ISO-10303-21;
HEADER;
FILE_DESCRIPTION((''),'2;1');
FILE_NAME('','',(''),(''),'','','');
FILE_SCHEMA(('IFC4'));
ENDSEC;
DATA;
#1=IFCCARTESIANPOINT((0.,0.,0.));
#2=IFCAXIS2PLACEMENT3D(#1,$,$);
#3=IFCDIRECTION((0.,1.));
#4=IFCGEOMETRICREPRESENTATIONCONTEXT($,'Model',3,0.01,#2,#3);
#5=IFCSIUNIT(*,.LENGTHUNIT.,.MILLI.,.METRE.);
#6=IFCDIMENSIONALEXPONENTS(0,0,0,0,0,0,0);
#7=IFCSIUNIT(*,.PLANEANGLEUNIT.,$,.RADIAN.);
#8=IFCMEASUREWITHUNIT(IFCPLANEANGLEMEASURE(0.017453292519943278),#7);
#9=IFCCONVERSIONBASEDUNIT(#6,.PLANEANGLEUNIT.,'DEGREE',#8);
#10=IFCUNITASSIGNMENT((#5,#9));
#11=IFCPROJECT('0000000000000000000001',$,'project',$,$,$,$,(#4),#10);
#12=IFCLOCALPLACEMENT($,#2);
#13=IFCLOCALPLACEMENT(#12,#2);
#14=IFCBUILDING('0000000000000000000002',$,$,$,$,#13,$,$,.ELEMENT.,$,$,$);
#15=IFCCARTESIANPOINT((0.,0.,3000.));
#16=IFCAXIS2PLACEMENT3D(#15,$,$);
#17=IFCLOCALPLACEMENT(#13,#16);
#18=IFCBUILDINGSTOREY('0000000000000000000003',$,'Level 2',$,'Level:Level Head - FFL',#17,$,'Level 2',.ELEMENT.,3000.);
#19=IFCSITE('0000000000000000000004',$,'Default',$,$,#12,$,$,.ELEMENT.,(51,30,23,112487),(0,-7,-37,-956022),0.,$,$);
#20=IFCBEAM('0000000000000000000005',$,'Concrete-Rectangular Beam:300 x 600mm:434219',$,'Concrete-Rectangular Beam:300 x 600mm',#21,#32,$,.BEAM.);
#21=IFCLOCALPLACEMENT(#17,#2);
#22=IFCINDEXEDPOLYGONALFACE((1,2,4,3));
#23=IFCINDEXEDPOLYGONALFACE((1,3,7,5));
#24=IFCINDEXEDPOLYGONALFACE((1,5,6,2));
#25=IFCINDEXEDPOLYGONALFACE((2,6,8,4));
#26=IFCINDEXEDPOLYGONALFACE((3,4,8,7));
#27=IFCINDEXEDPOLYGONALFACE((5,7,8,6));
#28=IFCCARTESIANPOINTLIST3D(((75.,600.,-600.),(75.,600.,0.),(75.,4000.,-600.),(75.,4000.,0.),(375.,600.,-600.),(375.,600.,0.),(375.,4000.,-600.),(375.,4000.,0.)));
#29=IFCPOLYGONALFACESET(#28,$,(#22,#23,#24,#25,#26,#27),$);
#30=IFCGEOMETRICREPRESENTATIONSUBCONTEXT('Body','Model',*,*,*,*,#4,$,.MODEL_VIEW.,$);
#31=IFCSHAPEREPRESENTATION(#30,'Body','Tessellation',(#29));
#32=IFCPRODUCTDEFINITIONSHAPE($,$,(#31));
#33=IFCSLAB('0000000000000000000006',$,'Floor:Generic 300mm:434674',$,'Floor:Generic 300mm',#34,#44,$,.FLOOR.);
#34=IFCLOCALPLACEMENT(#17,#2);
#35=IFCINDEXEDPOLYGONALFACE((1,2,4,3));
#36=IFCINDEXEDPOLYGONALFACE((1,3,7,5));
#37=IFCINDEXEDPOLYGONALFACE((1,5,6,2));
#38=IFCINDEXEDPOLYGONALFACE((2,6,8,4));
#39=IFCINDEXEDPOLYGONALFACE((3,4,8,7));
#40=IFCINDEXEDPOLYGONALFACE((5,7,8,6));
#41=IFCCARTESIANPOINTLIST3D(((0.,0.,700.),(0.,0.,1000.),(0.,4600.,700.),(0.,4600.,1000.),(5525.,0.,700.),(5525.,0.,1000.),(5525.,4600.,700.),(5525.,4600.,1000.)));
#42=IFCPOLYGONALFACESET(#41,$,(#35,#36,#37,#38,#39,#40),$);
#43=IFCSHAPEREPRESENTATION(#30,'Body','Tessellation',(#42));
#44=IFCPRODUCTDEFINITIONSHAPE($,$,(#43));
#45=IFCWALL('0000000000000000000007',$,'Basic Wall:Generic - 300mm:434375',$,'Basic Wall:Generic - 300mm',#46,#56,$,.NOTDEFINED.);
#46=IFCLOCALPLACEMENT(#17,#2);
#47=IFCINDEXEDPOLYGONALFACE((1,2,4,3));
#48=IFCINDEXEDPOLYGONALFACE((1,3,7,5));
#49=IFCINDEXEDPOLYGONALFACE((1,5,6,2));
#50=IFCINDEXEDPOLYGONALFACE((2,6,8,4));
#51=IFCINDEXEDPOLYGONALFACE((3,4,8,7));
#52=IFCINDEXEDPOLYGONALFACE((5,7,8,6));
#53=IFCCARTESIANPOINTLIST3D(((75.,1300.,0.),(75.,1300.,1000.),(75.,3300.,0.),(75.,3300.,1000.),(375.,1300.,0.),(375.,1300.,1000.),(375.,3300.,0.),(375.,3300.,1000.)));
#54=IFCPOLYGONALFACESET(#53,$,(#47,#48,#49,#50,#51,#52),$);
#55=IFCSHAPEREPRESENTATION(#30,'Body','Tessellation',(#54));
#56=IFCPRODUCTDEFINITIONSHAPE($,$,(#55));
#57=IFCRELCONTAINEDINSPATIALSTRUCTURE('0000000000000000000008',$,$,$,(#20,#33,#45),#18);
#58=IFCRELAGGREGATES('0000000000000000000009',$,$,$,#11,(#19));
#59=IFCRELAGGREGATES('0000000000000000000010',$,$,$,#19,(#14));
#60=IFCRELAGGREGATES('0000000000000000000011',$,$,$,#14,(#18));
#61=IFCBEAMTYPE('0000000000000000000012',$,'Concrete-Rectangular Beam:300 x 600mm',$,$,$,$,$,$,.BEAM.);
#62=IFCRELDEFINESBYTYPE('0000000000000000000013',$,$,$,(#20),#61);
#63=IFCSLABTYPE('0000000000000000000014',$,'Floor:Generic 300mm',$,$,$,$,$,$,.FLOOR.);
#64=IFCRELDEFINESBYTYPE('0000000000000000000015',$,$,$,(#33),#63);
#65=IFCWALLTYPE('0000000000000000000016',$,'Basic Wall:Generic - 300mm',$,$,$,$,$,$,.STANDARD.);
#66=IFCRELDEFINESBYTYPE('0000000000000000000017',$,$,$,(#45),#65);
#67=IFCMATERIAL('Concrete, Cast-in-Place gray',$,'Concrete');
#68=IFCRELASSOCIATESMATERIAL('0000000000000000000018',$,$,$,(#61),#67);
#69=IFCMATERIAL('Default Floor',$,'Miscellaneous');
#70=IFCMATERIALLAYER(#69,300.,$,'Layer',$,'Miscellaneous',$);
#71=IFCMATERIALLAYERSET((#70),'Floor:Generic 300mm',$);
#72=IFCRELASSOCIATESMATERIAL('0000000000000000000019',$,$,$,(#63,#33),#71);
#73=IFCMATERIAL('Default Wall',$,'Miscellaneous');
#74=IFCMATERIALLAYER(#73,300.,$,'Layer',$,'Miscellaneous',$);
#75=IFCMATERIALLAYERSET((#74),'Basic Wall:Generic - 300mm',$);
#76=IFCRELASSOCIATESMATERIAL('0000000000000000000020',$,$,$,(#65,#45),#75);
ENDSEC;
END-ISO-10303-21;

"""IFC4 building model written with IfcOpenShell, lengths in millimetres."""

from ifc_helpers import new_model, entity, si_unit, converted_unit, direction, frame, frame_2d, origin, origin_2d_with_axis, place, context, subcontext, project, spatial, rectangle, extrude, source, transform, mapped, material, layer, layer_set, layer_usage, material_profile, profile_set, type_object, type_shapes, element, save


model = new_model("IFC4")

# Units and contexts
model_context = context("Model", 3, precision=0.01, world=origin(), true_north=direction((0.0, 1.0)))
body_context = subcontext(model_context, "Body", "Model", "MODEL_VIEW")
ifc_project = project(units=[si_unit("LENGTHUNIT", "METRE", prefix="MILLI"), converted_unit("PLANEANGLEUNIT", "DEGREE", entity("IfcPlaneAngleMeasure", 0.017453292519943278), si_unit("PLANEANGLEUNIT", "RADIAN"), dimensions=[0, 0, 0, 0, 0, 0, 0])], contexts=[model_context])

# Site, building, storey
site_placement = place(None, origin())
site = spatial("IfcSite", under=ifc_project, at=site_placement, Name="Default", CompositionType="ELEMENT", RefLatitude=(51, 30, 23, 112487), RefLongitude=(0, -7, -37, -956022), RefElevation=0.0)
building_placement = place(site_placement, origin())
building = spatial("IfcBuilding", under=site, at=building_placement, CompositionType="ELEMENT")
storey_placement = place(building_placement, frame((0.0, 0.0, 3000.0)))
storey = spatial("IfcBuildingStorey", under=building, at=storey_placement, Name="Level 2", ObjectType="Level:Level Head - FFL", LongName="Level 2", CompositionType="ELEMENT", Elevation=3000.0)

# Beam
ifc_material_1 = material(Name="Concrete, Cast-in-Place gray", Category="Concrete")
ifc_material_profile = material_profile(ifc_material_1, rectangle(XDim=600.0, YDim=300.0, at=frame_2d((0.0, 0.0), x_axis=(0.0, 1.0))), Name="300 x 600mm")
ifc_profile_set = profile_set([ifc_material_profile], Name="300 x 600mm")
beam_type = type_object("IfcBeamType", Name="Concrete-Rectangular Beam:300 x 600mm", PredefinedType="BEAM", material=ifc_profile_set)
shared_shape = source(origin(), body_context, "Body", "SweptSolid", [
    extrude(rectangle(XDim=600.0, YDim=300.0, at=frame_2d((0.0, 0.0), x_axis=(0.0, 1.0))), frame((225.0, 4000.0, 2700.0), z_axis=(0.0, -1.0, 0.0), x_axis=(-1.0, 0.0, 0.0)), (0.0, 0.0, 1.0), 3400.0),
])
type_shapes(beam_type, [shared_shape])
beam_placement = place(storey_placement, frame((0.0, 0.0, -3000.0)))
element("IfcBeam", 1, at=beam_placement, inside=storey, type_object=beam_type, Name="Concrete-Rectangular Beam:300 x 600mm:434219", ObjectType="Concrete-Rectangular Beam:300 x 600mm", PredefinedType="BEAM", context=body_context, shape_type="MappedRepresentation", body=[
    mapped(shared_shape, transform((0.0, 0.0, 0.0), scale=1.0)),
])

# Slab
ifc_material_2 = material(Name="Default Floor", Category="Miscellaneous")
ifc_layer_1 = layer(ifc_material_2, 300.0, Name="Layer", Category="Miscellaneous")
ifc_layer_set_1 = layer_set([ifc_layer_1], Name="Floor:Generic 300mm")
ifc_layer_usage_1 = layer_usage(ifc_layer_set_1, "AXIS3", "POSITIVE", 0.0)
slab_type = type_object("IfcSlabType", Name="Floor:Generic 300mm", PredefinedType="FLOOR", material=ifc_layer_set_1)
slab_placement = place(storey_placement, origin())
element("IfcSlab", 2, at=slab_placement, inside=storey, type_object=slab_type, material=ifc_layer_usage_1, Name="Floor:Generic 300mm:434674", ObjectType="Floor:Generic 300mm", PredefinedType="FLOOR", context=body_context, shape_type="SweptSolid", body=[
    extrude(rectangle(XDim=4600.0, YDim=5525.0, at=origin_2d_with_axis()), frame((2762.5, 2300.0, 1000.0), z_axis=(0.0, 0.0, -1.0), x_axis=(0.0, 1.0, 0.0)), (0.0, 0.0, 1.0), 300.0),
])

# Wall
ifc_material_3 = material(Name="Default Wall", Category="Miscellaneous")
ifc_layer_2 = layer(ifc_material_3, 300.0, Name="Layer", Category="Miscellaneous")
ifc_layer_set_2 = layer_set([ifc_layer_2], Name="Basic Wall:Generic - 300mm")
ifc_layer_usage_2 = layer_usage(ifc_layer_set_2, "AXIS2", "NEGATIVE", 150.0)
wall_type = type_object("IfcWallType", Name="Basic Wall:Generic - 300mm", PredefinedType="STANDARD", material=ifc_layer_set_2)
wall_placement = place(storey_placement, frame((225.0, 3300.0, 0.0), z_axis=(0.0, 0.0, 1.0), x_axis=(0.0, -1.0, 0.0)))
element("IfcWall", 3, at=wall_placement, inside=storey, type_object=wall_type, material=ifc_layer_usage_2, Name="Basic Wall:Generic - 300mm:434375", ObjectType="Basic Wall:Generic - 300mm", PredefinedType="NOTDEFINED", context=body_context, shape_type="SweptSolid", body=[
    extrude(rectangle(XDim=2000.0, YDim=300.0, at=frame_2d((1000.0, 0.0), x_axis=(-1.0, 0.0))), origin(), (0.0, 0.0, 1.0), 1000.0),
])

save(model, "model.ifc")
